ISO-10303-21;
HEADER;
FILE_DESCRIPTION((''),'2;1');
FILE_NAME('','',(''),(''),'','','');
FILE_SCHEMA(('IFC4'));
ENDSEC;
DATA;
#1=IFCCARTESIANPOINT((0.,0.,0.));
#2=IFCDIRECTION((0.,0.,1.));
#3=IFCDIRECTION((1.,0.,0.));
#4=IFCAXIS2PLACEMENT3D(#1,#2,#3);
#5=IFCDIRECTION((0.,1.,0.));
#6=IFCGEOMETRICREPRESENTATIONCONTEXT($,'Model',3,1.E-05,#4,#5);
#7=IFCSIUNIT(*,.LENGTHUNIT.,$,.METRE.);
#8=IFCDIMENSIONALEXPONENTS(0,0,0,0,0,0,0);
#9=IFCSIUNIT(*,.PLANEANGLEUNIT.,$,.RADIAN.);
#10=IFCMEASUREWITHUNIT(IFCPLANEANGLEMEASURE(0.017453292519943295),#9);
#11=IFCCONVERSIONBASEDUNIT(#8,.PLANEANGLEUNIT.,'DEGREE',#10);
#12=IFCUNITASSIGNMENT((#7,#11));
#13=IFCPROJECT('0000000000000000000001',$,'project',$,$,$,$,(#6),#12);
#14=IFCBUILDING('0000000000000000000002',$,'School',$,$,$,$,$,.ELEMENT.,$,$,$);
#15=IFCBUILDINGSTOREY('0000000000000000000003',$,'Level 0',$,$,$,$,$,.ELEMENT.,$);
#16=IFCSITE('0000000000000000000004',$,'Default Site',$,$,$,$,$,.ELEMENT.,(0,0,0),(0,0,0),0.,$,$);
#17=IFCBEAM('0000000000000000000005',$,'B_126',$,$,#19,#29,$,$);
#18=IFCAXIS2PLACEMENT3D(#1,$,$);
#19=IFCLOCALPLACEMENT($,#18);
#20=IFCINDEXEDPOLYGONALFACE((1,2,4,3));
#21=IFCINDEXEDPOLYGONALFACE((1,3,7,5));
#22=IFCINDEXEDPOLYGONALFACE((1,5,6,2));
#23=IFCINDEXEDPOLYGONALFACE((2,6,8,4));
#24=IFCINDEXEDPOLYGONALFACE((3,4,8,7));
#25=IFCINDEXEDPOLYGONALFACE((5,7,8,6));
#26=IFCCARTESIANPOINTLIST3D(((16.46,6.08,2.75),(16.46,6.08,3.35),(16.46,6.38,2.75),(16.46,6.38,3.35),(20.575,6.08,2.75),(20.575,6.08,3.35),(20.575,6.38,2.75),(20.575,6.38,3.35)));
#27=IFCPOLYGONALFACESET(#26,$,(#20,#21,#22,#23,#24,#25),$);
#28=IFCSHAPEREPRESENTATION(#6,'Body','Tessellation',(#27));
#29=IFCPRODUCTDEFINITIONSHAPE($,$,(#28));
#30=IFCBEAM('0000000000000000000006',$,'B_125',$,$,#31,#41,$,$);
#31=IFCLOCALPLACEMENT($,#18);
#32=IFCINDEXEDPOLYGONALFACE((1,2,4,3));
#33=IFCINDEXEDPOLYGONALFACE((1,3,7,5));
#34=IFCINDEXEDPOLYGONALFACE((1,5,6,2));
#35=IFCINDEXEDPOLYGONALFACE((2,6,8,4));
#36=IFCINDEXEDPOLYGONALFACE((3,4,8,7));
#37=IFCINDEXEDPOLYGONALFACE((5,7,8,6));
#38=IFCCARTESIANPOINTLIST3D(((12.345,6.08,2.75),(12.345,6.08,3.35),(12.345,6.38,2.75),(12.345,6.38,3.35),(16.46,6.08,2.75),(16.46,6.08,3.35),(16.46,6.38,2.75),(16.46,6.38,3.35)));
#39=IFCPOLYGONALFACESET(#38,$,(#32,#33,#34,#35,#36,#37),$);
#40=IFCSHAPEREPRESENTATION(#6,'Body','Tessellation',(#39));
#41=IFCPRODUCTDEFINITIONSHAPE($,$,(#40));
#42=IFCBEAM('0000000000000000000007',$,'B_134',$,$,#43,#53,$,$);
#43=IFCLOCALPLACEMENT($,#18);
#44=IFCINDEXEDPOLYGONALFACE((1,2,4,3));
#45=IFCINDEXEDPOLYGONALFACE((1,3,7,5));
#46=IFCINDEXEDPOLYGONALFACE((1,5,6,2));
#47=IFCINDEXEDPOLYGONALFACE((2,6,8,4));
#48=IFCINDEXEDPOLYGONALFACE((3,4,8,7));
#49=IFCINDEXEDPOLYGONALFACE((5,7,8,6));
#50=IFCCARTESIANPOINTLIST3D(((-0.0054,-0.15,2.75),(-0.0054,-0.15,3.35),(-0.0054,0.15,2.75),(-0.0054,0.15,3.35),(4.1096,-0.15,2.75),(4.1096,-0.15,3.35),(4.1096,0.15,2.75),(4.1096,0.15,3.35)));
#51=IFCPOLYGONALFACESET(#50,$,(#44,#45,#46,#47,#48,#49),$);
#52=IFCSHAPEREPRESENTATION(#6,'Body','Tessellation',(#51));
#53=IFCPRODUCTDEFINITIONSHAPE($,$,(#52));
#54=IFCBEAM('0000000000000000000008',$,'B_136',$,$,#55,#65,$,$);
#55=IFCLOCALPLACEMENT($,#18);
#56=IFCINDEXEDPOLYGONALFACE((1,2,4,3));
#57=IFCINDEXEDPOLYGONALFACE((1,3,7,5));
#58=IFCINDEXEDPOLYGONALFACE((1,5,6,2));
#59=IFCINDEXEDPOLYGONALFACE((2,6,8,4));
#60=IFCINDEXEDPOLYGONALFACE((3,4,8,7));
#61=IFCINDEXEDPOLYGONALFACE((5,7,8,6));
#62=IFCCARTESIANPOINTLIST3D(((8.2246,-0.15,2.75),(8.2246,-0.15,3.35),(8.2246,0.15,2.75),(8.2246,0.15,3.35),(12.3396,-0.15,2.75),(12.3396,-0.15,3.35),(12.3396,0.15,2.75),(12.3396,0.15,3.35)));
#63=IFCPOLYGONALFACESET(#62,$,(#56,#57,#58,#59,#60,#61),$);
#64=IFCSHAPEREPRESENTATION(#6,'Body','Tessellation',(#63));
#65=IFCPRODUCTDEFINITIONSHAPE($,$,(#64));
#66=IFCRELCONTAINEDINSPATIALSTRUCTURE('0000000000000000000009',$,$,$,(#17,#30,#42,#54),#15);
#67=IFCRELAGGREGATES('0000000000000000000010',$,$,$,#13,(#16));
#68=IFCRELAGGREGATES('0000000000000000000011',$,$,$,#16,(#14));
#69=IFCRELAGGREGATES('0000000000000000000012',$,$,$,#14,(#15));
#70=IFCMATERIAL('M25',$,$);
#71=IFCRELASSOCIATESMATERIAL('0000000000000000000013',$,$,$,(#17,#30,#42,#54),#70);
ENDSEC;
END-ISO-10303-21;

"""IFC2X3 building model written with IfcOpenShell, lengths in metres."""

from ifc_helpers import new_model, entity, si_unit, converted_unit, direction, frame, frame_2d, origin_with_axes, place, context, project, spatial, rectangle, extrude, material, element, save


model = new_model("IFC2X3")

# Units and contexts
model_context = context("Model", 3, precision=1e-05, world=origin_with_axes(), true_north=direction((0.0, 1.0, 0.0)))
ifc_project = project(units=[si_unit("LENGTHUNIT", "METRE"), converted_unit("PLANEANGLEUNIT", "DEGREE", entity("IfcPlaneAngleMeasure", 0.017453292519943295), si_unit("PLANEANGLEUNIT", "RADIAN"), dimensions=[0, 0, 0, 0, 0, 0, 0])], contexts=[model_context])

# Site, building, storey
site = spatial("IfcSite", under=ifc_project, Name="Default Site", CompositionType="ELEMENT", RefLatitude=(0, 0, 0), RefLongitude=(0, 0, 0), RefElevation=0.0)
building = spatial("IfcBuilding", under=site, Name="School", CompositionType="ELEMENT")
storey = spatial("IfcBuildingStorey", under=building, Name="Level 0", CompositionType="ELEMENT")

# Beams
ifc_material = material(Name="M25")
placement = place(None, origin_with_axes())
element("IfcBeam", 1, at=placement, inside=storey, material=ifc_material, Name="B_126", context=model_context, shape_type="SweptSolid", body=[
    extrude(rectangle(XDim=0.3, YDim=0.6, at=frame_2d((0.0, 0.0), x_axis=(0.0, 1.0, 0.0))), frame((16.46, 6.23, 3.05), z_axis=(1.0, 0.0, 0.0), x_axis=(0.0, 0.0, -1.0)), (0.0, 0.0, 1.0), 4.115),
])
element("IfcBeam", 2, at=placement, inside=storey, material=ifc_material, Name="B_125", context=model_context, shape_type="SweptSolid", body=[
    extrude(rectangle(XDim=0.3, YDim=0.6, at=frame_2d((0.0, 0.0), x_axis=(0.0, 1.0, 0.0))), frame((12.345, 6.23, 3.05), z_axis=(1.0, 0.0, 0.0), x_axis=(0.0, 0.0, -1.0)), (0.0, 0.0, 1.0), 4.115),
])
element("IfcBeam", 3, at=placement, inside=storey, material=ifc_material, Name="B_134", context=model_context, shape_type="SweptSolid", body=[
    extrude(rectangle(XDim=0.3, YDim=0.6, at=frame_2d((0.0, 0.0), x_axis=(0.0, 1.0, 0.0))), frame((-0.0054, 0.0, 3.05), z_axis=(1.0, 0.0, 0.0), x_axis=(0.0, 0.0, -1.0)), (0.0, 0.0, 1.0), 4.115),
])
element("IfcBeam", 4, at=placement, inside=storey, material=ifc_material, Name="B_136", context=model_context, shape_type="SweptSolid", body=[
    extrude(rectangle(XDim=0.3, YDim=0.6, at=frame_2d((0.0, 0.0), x_axis=(0.0, 1.0, 0.0))), frame((8.2246, 0.0, 3.05), z_axis=(1.0, 0.0, 0.0), x_axis=(0.0, 0.0, -1.0)), (0.0, 0.0, 1.0), 4.115),
])

save(model, "model.ifc")
